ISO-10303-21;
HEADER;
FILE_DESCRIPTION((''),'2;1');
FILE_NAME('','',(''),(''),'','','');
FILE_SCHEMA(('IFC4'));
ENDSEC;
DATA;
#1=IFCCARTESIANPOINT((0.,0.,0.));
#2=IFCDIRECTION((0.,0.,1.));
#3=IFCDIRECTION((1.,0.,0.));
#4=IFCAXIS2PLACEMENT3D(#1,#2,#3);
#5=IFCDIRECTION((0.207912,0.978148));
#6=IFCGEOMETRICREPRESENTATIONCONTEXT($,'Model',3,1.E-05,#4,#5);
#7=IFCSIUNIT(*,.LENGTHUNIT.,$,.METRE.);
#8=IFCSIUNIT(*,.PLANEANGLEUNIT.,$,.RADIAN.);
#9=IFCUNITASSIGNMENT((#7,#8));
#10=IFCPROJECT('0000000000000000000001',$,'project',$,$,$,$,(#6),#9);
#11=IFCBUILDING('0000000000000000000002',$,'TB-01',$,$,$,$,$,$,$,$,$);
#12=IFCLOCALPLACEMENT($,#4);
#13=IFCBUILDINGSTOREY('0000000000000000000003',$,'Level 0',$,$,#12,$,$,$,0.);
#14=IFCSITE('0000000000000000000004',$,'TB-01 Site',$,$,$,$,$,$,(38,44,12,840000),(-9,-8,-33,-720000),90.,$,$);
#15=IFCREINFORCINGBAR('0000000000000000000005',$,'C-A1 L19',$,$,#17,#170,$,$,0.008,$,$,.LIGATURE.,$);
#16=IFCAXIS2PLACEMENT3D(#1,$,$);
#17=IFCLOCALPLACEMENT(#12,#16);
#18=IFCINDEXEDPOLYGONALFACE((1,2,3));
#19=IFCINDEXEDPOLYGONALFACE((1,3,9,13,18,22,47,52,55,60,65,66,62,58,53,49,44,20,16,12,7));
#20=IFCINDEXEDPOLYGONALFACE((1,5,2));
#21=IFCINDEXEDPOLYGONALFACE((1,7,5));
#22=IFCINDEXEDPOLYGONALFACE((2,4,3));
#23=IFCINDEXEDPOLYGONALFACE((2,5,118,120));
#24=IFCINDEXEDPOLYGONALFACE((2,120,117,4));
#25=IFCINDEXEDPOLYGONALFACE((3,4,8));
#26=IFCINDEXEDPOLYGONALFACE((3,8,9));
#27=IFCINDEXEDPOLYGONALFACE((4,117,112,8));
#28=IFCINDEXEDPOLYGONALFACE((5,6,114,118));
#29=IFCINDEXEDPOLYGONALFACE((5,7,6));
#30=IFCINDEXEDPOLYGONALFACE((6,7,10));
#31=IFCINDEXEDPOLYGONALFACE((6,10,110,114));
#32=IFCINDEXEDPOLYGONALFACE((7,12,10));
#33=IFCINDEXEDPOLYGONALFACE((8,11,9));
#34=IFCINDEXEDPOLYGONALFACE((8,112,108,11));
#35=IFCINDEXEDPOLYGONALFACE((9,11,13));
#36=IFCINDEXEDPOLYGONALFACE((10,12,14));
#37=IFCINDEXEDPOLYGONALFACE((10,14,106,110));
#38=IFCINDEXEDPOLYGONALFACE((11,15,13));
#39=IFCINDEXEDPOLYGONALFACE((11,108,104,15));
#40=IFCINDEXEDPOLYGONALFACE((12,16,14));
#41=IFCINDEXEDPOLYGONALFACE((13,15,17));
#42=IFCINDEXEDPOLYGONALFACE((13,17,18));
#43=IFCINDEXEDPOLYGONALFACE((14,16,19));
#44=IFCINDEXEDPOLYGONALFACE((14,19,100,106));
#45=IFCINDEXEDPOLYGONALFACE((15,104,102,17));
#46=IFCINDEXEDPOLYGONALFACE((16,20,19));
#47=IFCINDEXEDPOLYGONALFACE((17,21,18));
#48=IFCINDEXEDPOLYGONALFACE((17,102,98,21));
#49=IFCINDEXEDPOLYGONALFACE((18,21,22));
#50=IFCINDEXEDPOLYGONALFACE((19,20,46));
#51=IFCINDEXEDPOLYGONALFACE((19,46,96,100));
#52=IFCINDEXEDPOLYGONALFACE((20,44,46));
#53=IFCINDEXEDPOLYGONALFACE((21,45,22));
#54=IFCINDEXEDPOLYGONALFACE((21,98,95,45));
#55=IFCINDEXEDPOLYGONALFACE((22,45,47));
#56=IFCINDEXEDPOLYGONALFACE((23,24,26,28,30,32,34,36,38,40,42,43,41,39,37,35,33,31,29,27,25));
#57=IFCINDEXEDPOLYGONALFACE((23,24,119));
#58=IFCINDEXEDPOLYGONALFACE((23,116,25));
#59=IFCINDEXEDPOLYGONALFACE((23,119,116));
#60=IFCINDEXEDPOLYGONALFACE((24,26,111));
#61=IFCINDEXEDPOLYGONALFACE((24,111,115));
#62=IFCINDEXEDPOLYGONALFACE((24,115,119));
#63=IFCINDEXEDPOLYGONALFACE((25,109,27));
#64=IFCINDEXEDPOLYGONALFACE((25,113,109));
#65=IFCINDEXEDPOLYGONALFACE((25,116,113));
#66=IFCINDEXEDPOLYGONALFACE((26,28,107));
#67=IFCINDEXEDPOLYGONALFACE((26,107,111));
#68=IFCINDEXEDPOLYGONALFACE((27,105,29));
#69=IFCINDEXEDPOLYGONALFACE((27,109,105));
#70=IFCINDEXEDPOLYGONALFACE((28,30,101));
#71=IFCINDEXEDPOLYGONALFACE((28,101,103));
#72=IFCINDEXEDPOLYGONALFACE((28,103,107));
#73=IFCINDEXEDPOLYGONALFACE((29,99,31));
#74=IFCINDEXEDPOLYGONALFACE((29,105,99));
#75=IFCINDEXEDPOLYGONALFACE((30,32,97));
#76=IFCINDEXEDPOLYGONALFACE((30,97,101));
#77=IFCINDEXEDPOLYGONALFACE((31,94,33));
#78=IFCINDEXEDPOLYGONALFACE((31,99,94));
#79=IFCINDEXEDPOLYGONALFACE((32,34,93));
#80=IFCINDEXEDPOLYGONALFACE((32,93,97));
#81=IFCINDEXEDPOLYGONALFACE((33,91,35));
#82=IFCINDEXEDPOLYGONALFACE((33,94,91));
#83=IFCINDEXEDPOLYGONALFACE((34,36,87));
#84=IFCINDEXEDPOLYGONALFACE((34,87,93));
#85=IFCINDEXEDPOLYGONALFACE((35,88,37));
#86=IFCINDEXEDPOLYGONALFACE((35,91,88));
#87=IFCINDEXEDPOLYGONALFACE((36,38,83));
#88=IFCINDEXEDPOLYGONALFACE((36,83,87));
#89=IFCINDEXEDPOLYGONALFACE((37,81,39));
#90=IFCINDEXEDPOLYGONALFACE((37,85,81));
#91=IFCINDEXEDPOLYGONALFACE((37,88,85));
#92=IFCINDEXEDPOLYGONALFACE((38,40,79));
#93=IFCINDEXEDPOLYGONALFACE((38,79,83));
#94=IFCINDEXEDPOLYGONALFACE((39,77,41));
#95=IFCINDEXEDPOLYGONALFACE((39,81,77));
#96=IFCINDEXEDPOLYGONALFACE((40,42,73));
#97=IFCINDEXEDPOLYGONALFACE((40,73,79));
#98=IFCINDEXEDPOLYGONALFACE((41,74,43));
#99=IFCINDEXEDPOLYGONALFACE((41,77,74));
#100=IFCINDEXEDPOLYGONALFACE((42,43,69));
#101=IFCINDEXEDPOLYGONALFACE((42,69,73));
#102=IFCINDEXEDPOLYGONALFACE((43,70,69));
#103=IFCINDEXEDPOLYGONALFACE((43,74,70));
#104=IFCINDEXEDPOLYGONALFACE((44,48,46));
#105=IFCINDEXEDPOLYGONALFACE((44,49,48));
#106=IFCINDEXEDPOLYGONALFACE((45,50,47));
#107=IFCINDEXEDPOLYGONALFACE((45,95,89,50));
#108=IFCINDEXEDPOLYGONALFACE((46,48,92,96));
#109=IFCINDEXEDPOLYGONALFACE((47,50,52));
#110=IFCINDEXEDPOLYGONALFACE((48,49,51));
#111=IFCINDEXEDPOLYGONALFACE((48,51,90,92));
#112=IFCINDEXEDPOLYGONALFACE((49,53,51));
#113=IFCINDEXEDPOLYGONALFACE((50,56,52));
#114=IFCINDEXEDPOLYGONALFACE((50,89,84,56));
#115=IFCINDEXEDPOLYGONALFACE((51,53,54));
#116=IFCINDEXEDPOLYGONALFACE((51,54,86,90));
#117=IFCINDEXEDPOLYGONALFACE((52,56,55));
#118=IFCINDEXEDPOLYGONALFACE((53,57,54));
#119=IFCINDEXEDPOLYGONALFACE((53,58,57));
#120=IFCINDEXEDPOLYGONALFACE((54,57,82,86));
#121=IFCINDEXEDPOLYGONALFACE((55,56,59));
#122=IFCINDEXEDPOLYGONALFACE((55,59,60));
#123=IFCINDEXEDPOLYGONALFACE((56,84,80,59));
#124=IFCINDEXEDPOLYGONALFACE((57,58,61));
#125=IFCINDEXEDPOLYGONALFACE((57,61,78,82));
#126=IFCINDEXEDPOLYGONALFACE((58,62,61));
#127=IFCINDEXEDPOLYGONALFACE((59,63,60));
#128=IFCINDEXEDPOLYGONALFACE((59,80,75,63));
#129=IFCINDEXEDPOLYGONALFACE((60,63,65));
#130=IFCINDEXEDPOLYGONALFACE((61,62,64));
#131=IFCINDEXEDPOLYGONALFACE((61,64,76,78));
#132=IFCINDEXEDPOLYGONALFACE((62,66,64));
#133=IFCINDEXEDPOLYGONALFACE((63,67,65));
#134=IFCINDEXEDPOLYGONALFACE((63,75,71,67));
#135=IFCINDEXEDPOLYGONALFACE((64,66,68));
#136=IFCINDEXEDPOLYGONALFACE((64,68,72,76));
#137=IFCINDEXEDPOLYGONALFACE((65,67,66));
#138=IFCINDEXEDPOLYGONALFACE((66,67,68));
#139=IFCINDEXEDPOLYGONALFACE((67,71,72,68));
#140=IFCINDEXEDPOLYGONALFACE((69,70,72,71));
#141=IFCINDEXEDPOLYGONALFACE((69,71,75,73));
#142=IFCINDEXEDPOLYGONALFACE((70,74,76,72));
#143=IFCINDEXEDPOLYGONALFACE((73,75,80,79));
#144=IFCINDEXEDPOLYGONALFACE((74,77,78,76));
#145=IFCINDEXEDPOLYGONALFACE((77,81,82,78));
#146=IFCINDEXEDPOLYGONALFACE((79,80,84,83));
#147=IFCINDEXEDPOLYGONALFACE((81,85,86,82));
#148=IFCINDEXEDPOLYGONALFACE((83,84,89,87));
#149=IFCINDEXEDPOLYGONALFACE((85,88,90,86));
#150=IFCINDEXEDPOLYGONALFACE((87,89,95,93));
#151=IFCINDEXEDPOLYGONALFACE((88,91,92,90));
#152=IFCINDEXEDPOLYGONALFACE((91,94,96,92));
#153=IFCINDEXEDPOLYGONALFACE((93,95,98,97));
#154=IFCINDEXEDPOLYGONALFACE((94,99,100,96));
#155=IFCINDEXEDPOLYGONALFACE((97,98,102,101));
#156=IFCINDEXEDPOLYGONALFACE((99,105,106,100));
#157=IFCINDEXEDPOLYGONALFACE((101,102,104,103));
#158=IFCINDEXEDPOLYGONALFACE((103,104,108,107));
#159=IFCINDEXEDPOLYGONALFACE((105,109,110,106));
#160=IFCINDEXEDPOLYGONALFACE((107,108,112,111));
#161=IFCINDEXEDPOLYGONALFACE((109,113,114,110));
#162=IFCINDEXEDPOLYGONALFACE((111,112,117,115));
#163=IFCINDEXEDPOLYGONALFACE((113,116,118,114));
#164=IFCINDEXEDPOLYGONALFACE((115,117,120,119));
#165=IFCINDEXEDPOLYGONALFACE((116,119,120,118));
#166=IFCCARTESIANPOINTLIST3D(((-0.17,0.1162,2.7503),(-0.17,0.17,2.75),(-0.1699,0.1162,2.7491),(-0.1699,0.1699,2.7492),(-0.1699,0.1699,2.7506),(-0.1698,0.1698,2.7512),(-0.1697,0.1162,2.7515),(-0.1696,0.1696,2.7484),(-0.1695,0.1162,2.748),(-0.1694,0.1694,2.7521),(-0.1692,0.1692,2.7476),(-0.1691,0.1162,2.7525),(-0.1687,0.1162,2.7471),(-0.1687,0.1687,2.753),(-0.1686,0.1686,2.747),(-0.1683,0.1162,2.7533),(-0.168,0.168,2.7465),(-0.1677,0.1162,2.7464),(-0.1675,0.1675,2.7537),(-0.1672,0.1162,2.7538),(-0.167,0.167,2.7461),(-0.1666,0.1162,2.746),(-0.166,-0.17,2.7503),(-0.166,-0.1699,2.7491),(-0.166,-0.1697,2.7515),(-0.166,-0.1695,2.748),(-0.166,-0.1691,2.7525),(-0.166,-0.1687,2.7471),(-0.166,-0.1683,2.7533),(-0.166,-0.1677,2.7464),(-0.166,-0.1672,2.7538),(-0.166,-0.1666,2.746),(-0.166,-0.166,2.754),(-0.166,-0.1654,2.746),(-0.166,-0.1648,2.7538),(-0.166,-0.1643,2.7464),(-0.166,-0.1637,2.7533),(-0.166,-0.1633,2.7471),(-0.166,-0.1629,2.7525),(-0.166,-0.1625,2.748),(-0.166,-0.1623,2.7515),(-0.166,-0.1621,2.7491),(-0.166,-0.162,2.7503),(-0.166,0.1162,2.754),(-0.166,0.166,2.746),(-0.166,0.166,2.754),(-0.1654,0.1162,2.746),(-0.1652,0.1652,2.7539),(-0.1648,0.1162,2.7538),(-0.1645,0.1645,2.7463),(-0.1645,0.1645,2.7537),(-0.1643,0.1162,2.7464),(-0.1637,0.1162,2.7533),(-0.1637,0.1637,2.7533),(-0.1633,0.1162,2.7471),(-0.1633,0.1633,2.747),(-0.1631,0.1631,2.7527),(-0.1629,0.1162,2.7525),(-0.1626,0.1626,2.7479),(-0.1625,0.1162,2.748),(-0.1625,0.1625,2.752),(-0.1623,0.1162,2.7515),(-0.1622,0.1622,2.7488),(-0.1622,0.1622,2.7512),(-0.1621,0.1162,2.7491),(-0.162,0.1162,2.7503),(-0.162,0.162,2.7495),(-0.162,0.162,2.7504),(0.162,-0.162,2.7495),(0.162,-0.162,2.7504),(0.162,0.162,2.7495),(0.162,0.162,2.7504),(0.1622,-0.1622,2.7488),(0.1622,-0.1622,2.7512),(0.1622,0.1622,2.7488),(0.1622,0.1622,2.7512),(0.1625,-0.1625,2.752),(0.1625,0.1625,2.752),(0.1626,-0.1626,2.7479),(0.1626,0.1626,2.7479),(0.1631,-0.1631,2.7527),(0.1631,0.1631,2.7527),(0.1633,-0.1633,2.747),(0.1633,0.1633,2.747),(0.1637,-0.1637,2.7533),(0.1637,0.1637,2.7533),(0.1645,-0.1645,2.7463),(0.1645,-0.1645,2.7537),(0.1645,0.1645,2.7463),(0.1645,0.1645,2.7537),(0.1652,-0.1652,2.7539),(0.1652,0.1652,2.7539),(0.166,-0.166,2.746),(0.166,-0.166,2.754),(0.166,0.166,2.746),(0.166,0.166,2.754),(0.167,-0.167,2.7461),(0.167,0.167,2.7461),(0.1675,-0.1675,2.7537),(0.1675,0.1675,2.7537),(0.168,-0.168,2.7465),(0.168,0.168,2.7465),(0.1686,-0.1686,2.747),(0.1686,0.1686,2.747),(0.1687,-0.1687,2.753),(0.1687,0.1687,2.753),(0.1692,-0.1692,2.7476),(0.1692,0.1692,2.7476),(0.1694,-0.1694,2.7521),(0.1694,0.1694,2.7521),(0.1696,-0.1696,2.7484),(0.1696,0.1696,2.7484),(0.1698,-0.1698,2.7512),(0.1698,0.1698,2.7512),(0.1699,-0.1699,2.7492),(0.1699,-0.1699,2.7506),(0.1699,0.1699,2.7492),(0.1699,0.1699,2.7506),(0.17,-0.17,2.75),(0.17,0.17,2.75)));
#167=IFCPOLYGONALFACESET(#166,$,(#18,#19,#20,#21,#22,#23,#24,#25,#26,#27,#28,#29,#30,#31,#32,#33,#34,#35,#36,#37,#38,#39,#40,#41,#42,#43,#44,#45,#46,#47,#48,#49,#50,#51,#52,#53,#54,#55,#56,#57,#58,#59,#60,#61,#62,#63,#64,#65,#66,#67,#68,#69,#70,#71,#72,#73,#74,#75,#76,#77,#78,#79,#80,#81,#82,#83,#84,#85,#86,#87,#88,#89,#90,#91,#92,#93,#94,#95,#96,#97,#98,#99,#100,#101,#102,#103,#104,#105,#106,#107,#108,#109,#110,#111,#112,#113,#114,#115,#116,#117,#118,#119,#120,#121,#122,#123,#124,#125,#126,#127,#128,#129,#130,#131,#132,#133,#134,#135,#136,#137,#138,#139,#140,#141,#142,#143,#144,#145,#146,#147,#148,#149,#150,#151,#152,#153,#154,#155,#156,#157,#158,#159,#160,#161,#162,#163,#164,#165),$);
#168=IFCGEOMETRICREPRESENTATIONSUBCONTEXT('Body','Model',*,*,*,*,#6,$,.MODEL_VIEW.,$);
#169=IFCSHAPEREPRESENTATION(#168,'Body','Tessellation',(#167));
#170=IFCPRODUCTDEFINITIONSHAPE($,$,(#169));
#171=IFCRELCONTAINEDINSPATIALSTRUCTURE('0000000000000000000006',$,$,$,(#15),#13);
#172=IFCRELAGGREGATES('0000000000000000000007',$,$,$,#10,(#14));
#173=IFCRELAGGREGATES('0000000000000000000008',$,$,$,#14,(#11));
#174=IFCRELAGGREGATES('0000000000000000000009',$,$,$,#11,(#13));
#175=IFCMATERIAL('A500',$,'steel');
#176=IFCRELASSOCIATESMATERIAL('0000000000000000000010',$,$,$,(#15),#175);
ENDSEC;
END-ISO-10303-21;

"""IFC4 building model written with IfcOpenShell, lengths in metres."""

from ifc_helpers import new_model, entity, si_unit, direction, origin_with_axes, place, context, subcontext, project, spatial, material, element, save


model = new_model("IFC4")

# Units and contexts
model_context = context("Model", 3, precision=1e-05, world=origin_with_axes(), true_north=direction((0.207912, 0.978148)))
body_context = subcontext(model_context, "Body", "Model", "MODEL_VIEW")
ifc_project = project(units=[si_unit("LENGTHUNIT", "METRE"), si_unit("PLANEANGLEUNIT", "RADIAN")], contexts=[model_context])

# Site, building, storey
site = spatial("IfcSite", under=ifc_project, Name="TB-01 Site", RefLatitude=(38, 44, 12, 840000), RefLongitude=(-9, -8, -33, -720000), RefElevation=90.0)
building = spatial("IfcBuilding", under=site, Name="TB-01")
storey_placement = place(None, origin_with_axes())
storey = spatial("IfcBuildingStorey", under=building, at=storey_placement, Name="Level 0", Elevation=0.0)

# Reinforcing bar
ifc_material_1 = material(Name="A500", Category="steel")
reinforcing_bar_1_placement = place(storey_placement, origin_with_axes())
element("IfcReinforcingBar", 1, at=reinforcing_bar_1_placement, inside=storey, material=ifc_material_1, Name="C-A1 L19", NominalDiameter=0.008, PredefinedType="LIGATURE", context=body_context, shape_type="AdvancedSweptSolid", body=[
    entity("IfcSweptDiskSolid", entity("IfcPolyline", [entity("IfcCartesianPoint", [-0.166, -0.166, 2.75]), entity("IfcCartesianPoint", [0.166, -0.166, 2.75]), entity("IfcCartesianPoint", [0.166, 0.166, 2.75]), entity("IfcCartesianPoint", [-0.166, 0.166, 2.75]), entity("IfcCartesianPoint", [-0.166, 0.1162, 2.75])]), 0.004),
])

save(model, "model.ifc")
